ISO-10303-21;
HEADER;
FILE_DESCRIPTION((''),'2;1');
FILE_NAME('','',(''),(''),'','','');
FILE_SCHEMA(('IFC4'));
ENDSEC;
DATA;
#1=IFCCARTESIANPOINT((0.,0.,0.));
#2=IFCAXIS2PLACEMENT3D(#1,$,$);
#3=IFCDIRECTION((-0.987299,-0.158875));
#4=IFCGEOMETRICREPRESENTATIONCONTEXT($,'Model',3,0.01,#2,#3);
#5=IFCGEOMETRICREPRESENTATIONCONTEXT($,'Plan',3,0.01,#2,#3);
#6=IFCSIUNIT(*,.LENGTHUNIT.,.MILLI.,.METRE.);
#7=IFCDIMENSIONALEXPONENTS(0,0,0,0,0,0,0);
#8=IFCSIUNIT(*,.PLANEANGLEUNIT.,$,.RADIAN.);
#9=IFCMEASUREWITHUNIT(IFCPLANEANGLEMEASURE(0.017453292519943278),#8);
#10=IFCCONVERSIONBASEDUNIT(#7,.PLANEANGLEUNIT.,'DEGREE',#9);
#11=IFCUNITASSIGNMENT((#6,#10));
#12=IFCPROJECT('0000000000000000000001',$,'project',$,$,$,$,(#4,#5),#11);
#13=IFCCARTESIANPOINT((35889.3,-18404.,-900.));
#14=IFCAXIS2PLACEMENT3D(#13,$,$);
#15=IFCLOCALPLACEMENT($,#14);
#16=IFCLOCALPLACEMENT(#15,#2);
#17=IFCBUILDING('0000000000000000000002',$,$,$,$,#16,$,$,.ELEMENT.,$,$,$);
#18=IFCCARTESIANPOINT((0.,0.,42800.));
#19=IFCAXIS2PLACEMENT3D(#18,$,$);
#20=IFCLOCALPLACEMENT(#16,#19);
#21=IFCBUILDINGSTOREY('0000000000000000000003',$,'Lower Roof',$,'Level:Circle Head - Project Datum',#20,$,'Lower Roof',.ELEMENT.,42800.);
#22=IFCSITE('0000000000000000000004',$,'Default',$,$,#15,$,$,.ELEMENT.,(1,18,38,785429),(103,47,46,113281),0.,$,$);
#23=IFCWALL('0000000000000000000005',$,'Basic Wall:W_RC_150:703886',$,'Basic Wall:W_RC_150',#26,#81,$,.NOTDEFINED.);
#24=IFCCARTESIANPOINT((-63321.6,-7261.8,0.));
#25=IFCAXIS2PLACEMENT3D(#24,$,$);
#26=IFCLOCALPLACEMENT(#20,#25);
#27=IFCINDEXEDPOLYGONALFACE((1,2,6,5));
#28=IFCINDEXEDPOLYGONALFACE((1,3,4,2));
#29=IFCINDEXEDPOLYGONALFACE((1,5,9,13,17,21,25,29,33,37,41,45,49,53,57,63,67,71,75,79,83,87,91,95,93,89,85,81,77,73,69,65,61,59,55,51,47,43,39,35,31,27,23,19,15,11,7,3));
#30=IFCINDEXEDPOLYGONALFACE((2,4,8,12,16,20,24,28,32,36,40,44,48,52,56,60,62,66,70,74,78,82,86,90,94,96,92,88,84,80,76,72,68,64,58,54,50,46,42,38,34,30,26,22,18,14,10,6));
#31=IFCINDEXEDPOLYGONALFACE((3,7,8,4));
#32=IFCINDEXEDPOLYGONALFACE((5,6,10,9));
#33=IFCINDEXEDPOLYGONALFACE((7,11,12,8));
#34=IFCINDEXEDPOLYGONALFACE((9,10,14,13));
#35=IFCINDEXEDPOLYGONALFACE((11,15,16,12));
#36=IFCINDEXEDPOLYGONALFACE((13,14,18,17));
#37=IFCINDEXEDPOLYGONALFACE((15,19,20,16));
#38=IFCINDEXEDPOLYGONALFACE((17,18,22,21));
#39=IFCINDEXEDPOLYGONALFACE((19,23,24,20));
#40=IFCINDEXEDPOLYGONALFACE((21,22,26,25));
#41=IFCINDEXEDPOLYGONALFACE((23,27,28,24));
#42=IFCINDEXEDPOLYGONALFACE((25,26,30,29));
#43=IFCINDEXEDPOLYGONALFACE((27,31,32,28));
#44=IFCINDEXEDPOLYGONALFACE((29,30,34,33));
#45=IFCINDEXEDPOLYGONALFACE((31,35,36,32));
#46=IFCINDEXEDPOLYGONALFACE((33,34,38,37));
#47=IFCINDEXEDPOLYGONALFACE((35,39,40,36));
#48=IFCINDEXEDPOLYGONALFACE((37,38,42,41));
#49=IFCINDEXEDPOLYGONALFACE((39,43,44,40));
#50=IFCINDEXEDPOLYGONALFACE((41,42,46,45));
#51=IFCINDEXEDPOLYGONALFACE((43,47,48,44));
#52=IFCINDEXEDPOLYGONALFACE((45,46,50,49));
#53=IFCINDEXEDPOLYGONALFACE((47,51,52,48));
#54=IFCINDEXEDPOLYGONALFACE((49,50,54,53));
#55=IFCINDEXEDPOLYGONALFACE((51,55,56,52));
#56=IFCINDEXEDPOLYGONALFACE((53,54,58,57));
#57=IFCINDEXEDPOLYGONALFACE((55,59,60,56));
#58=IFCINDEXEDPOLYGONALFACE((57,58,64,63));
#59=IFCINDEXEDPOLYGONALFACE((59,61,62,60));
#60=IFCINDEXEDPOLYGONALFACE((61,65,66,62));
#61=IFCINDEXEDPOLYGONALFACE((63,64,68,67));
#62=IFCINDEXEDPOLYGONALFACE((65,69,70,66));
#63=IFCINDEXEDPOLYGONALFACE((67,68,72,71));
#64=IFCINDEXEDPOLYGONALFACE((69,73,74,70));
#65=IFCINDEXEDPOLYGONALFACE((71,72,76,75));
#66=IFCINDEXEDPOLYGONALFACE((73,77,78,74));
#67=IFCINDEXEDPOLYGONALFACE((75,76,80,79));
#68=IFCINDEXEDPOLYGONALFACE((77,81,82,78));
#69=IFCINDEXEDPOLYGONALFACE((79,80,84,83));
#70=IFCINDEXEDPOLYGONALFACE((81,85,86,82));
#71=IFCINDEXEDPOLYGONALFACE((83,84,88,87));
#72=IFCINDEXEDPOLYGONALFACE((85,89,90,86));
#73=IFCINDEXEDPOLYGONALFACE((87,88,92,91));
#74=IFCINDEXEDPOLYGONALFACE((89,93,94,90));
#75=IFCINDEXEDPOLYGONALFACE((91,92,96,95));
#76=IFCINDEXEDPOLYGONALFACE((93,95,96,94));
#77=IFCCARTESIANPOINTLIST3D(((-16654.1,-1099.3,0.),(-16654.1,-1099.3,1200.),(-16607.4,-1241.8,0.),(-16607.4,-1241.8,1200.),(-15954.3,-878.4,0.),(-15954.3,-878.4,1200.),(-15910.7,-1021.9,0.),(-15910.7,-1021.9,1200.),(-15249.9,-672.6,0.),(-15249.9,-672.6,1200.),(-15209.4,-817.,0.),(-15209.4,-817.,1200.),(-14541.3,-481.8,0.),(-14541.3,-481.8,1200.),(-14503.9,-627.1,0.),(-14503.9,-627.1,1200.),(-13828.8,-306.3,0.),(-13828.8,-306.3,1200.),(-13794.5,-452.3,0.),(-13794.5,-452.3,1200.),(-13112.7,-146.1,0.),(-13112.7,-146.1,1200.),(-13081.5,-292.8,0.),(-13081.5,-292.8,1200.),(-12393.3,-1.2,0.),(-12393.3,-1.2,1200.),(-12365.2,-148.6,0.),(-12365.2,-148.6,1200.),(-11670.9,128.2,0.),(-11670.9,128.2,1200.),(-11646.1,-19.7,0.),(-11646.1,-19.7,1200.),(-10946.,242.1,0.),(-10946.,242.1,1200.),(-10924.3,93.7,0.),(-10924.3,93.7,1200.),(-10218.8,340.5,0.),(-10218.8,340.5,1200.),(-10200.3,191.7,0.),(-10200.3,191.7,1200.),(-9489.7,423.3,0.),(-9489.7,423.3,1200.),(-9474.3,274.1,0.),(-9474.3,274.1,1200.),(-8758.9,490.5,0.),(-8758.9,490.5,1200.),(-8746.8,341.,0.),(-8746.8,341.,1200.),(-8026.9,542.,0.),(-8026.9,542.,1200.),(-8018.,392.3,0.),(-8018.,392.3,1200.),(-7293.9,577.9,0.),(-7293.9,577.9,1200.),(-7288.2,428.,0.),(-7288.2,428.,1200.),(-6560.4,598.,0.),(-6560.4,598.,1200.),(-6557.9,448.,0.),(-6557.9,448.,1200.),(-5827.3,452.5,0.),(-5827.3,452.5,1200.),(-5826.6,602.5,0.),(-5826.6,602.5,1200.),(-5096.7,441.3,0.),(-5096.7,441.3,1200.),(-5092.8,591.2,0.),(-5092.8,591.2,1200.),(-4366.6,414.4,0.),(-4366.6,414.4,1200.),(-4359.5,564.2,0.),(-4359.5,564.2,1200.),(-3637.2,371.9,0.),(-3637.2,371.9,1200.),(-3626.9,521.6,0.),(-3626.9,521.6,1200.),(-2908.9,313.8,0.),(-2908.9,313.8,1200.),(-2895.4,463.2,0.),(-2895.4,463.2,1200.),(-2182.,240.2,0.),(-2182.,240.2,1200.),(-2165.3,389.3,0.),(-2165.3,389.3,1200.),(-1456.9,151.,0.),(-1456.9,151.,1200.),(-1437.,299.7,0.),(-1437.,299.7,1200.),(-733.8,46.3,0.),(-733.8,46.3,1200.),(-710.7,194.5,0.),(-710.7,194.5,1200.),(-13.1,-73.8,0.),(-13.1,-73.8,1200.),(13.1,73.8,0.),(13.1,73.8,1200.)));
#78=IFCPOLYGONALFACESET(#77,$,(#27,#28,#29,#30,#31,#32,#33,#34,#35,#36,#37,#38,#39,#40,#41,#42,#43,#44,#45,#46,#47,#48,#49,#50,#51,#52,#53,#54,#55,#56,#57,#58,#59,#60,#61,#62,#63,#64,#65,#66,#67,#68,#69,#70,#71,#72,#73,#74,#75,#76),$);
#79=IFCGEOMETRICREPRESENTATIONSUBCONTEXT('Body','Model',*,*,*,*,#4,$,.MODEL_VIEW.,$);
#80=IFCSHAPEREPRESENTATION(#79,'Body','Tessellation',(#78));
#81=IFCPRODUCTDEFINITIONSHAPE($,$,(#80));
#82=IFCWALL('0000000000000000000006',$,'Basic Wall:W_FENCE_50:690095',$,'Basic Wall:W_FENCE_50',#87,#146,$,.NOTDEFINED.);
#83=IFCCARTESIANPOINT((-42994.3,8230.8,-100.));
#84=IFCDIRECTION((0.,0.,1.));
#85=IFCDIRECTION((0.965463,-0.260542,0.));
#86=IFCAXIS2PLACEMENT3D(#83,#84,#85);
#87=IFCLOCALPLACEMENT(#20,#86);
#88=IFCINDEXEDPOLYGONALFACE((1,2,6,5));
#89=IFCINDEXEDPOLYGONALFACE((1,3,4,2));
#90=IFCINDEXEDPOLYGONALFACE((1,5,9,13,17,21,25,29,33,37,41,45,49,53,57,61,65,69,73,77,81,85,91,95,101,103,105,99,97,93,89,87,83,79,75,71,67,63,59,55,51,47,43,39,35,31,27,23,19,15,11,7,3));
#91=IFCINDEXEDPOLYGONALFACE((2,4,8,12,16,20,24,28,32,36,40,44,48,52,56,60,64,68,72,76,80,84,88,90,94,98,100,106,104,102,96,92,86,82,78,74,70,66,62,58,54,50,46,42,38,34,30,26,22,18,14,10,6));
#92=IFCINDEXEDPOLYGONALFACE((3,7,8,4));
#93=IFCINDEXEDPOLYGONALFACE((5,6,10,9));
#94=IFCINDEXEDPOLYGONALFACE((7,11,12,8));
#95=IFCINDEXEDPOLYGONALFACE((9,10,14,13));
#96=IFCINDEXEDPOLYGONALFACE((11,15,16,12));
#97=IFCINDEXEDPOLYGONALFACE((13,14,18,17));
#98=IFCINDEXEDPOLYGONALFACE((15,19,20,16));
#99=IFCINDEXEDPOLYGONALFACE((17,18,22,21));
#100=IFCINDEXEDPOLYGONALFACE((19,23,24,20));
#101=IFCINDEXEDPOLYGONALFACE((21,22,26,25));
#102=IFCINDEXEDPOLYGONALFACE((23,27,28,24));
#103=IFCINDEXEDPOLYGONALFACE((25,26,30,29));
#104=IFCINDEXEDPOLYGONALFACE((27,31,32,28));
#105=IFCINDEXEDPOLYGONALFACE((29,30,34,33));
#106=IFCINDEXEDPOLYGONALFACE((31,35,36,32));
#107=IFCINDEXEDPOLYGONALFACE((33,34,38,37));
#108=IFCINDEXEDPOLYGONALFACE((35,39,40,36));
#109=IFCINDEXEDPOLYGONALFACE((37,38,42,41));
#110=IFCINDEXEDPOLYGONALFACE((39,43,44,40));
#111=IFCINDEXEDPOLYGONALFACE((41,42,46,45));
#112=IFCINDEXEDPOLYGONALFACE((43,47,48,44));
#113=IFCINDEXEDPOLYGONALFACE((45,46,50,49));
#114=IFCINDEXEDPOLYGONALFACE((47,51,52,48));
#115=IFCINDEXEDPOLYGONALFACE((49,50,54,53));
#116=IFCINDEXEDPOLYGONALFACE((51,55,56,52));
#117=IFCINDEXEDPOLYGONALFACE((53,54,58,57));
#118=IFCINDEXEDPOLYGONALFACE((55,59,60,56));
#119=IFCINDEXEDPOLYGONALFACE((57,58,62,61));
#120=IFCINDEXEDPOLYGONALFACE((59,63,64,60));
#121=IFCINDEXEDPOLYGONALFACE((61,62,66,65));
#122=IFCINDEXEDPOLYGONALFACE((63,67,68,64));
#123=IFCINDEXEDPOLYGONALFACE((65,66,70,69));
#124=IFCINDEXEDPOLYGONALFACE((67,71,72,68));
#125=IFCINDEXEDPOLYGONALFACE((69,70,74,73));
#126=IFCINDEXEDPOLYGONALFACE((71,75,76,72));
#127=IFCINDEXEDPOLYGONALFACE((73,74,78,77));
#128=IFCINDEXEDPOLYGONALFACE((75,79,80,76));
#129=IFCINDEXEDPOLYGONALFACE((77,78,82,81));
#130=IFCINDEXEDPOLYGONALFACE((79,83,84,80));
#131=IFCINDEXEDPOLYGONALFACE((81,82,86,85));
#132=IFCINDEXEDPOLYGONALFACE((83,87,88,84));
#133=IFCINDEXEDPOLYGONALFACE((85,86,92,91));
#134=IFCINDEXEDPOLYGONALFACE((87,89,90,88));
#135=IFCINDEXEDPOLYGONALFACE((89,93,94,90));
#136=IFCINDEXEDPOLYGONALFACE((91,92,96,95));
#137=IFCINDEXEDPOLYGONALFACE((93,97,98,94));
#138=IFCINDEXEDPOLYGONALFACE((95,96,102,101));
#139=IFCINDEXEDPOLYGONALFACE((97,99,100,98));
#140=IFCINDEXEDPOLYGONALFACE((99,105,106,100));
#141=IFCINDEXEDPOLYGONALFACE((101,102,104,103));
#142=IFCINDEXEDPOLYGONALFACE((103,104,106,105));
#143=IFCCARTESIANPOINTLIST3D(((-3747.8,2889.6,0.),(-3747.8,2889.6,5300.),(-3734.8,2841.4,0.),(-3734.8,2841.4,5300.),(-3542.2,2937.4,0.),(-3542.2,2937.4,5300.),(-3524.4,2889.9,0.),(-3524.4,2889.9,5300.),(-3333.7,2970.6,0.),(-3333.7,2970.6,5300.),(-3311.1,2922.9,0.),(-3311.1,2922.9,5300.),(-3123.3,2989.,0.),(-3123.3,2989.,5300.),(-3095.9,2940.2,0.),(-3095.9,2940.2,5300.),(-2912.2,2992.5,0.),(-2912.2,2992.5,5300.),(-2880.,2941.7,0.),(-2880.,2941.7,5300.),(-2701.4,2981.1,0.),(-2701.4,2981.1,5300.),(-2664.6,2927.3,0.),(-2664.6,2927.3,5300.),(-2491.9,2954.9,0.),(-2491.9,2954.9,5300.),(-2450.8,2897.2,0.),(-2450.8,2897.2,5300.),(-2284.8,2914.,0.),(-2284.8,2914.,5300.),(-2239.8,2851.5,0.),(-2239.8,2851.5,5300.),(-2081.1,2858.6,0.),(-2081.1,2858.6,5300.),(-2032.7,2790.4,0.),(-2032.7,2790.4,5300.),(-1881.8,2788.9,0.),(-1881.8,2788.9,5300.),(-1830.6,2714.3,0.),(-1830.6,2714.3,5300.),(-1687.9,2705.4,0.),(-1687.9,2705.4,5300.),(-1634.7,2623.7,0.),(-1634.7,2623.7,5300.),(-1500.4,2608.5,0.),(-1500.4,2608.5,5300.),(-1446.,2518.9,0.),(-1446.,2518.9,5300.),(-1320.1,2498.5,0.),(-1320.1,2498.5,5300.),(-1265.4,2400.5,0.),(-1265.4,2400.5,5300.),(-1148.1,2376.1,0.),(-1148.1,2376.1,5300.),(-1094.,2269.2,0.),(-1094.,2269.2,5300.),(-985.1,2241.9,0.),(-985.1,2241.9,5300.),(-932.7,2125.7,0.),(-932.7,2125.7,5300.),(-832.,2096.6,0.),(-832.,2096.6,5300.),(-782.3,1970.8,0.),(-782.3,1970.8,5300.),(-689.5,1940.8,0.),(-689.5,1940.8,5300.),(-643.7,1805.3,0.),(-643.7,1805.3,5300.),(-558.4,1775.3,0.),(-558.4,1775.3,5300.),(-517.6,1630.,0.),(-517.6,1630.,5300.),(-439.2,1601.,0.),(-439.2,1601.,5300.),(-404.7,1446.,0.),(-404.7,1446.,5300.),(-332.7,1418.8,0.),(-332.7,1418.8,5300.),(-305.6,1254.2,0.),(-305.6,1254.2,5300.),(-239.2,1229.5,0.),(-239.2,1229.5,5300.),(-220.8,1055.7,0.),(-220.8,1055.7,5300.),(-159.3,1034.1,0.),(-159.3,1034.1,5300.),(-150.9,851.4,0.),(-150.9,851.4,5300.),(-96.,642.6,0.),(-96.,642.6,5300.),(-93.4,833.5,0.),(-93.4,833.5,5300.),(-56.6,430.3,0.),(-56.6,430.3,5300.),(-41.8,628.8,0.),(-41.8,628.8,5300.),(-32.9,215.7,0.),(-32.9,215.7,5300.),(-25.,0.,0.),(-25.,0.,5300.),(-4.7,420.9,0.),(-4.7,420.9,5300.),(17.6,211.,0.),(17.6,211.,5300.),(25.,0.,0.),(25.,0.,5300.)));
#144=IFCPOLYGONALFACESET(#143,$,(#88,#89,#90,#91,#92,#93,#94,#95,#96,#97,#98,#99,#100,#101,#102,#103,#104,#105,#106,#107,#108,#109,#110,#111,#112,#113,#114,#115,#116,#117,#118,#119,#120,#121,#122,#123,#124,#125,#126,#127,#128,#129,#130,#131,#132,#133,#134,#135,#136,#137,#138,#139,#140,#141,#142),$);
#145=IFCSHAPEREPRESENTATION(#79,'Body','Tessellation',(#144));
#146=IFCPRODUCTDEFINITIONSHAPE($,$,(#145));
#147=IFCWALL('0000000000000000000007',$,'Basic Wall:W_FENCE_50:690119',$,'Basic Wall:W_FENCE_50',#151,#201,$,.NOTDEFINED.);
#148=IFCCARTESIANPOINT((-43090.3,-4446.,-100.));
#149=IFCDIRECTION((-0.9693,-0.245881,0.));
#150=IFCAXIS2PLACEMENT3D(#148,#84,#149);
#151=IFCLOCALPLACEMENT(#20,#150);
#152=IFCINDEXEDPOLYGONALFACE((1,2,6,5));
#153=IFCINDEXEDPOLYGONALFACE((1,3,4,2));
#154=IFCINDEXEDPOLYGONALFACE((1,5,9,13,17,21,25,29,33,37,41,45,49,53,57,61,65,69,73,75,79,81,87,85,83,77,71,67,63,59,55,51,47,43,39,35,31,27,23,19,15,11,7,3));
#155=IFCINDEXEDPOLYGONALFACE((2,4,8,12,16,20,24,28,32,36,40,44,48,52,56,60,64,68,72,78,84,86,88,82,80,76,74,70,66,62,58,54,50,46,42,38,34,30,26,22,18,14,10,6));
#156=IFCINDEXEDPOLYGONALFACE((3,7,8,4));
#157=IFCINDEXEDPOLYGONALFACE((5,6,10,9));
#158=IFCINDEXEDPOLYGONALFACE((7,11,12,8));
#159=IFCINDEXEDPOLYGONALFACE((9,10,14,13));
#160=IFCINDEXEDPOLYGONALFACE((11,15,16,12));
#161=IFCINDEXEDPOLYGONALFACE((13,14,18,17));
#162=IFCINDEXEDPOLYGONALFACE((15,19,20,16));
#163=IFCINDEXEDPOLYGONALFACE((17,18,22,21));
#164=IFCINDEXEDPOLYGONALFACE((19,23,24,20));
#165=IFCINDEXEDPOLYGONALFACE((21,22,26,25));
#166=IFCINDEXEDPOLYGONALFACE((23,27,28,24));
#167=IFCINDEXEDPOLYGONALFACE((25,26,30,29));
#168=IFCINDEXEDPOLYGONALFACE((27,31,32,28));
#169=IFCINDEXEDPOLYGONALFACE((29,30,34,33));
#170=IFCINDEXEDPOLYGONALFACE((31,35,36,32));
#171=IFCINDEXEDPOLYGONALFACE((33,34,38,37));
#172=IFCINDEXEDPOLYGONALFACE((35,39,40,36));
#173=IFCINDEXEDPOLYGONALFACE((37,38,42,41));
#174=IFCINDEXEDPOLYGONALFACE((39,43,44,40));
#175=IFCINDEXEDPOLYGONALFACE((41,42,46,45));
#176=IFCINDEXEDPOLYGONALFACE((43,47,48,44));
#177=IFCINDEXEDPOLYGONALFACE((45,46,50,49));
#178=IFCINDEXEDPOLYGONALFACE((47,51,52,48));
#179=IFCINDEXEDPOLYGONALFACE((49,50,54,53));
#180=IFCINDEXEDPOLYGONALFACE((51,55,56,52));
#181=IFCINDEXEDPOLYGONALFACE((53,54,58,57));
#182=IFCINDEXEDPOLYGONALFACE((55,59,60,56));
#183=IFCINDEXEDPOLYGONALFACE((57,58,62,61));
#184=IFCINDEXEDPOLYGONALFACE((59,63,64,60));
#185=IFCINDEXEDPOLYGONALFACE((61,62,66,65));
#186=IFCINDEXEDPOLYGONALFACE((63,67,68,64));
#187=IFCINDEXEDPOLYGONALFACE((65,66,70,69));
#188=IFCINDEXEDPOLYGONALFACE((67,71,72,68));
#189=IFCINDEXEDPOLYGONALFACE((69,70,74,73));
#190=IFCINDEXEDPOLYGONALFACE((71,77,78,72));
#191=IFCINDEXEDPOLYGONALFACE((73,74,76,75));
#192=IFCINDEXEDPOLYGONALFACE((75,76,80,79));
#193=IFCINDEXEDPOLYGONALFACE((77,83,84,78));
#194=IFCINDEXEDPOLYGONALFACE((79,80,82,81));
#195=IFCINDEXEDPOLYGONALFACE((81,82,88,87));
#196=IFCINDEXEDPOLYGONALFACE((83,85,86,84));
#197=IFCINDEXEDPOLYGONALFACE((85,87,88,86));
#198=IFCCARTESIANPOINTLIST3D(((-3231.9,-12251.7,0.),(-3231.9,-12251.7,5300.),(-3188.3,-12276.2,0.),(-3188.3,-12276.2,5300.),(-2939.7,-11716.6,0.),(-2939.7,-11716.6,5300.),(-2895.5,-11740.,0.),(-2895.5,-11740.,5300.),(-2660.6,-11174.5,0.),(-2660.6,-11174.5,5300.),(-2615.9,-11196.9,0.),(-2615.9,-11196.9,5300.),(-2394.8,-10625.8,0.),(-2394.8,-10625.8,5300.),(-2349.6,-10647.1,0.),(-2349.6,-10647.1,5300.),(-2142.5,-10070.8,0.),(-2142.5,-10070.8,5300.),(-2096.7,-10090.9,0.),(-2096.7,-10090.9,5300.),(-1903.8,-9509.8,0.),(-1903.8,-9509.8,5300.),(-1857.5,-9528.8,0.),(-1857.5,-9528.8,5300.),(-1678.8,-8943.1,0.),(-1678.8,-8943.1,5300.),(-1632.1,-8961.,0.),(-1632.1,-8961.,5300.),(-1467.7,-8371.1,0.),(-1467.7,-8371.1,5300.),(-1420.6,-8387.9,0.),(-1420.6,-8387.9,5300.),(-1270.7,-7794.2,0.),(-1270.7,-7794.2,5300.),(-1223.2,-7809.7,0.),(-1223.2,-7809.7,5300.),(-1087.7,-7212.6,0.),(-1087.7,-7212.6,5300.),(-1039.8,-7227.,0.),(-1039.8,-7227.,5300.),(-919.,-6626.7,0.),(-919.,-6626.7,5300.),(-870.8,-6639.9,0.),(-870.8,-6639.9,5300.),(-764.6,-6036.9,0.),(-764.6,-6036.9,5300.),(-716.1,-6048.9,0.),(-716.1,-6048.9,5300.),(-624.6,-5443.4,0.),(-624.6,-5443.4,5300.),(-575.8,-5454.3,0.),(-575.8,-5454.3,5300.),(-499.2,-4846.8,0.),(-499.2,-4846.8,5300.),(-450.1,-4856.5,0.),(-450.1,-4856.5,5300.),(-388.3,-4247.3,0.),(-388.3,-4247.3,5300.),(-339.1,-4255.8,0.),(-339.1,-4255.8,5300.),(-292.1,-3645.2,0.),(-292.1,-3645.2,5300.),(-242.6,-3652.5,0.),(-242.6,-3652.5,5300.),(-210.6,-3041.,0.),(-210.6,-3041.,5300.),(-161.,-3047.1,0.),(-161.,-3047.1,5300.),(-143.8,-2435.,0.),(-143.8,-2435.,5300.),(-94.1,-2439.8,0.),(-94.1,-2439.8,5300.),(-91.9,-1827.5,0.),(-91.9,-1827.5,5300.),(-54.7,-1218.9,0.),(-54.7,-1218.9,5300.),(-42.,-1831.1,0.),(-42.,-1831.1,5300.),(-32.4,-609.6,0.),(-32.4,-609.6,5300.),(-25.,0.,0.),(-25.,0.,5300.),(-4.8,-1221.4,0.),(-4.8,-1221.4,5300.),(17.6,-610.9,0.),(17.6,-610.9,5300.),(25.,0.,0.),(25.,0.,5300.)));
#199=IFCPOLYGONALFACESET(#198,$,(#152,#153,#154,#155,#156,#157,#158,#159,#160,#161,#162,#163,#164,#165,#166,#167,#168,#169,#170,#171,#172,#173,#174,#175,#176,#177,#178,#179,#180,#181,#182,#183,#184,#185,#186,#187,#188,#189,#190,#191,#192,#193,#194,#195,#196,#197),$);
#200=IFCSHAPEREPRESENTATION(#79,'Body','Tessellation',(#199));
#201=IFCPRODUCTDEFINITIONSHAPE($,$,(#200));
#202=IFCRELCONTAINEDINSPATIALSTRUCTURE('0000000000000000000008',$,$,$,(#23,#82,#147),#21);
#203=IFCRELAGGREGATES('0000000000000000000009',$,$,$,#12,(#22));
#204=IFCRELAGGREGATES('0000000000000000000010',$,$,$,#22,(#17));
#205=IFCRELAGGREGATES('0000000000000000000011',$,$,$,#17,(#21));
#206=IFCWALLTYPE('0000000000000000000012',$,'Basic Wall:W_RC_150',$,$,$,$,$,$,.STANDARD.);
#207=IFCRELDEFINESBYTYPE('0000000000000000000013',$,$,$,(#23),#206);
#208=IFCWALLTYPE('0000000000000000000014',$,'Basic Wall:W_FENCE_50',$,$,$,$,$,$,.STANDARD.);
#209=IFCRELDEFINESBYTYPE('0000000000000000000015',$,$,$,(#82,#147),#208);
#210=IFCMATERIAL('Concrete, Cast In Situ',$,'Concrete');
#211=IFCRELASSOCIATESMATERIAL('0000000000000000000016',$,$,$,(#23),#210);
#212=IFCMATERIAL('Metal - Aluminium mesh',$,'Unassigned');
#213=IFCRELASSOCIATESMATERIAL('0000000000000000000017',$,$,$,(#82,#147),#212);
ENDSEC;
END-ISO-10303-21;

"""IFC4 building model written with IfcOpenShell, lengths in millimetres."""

from ifc_helpers import new_model, entity, si_unit, converted_unit, direction, frame, origin, place, context, subcontext, project, spatial, line, arc, indexed_curve, outline, extrude, material, type_object, element, save


model = new_model("IFC4")

# Units and contexts
model_context = context("Model", 3, precision=0.01, world=origin(), true_north=direction((-0.987299, -0.158875)))
plan_context = context("Plan", 3, precision=0.01, world=origin(), true_north=direction((-0.987299, -0.158875)))
body_context = subcontext(model_context, "Body", "Model", "MODEL_VIEW")
ifc_project = project(units=[si_unit("LENGTHUNIT", "METRE", prefix="MILLI"), converted_unit("PLANEANGLEUNIT", "DEGREE", entity("IfcPlaneAngleMeasure", 0.017453292519943278), si_unit("PLANEANGLEUNIT", "RADIAN"), dimensions=[0, 0, 0, 0, 0, 0, 0])], contexts=[model_context, plan_context])

# Site, building, storey
site_placement = place(None, frame((35889.3, -18404.0, -900.0)))
site = spatial("IfcSite", under=ifc_project, at=site_placement, Name="Default", CompositionType="ELEMENT", RefLatitude=(1, 18, 38, 785429), RefLongitude=(103, 47, 46, 113281), RefElevation=0.0)
building_placement = place(site_placement, origin())
building = spatial("IfcBuilding", under=site, at=building_placement, CompositionType="ELEMENT")
storey_placement = place(building_placement, frame((0.0, 0.0, 42800.0)))
storey = spatial("IfcBuildingStorey", under=building, at=storey_placement, Name="Lower Roof", ObjectType="Level:Circle Head - Project Datum", LongName="Lower Roof", CompositionType="ELEMENT", Elevation=42800.0)

# Walls
ifc_material_1 = material(Name="Concrete, Cast In Situ", Category="Concrete")
wall_type_1 = type_object("IfcWallType", Name="Basic Wall:W_RC_150", PredefinedType="STANDARD")
wall_1_placement = place(storey_placement, frame((-63321.6, -7261.8, 0.0)))
element("IfcWall", 1, at=wall_1_placement, inside=storey, type_object=wall_type_1, material=ifc_material_1, Name="Basic Wall:W_RC_150:703886", ObjectType="Basic Wall:W_RC_150", PredefinedType="NOTDEFINED", context=body_context, shape_type="SweptSolid", body=[
    extrude(outline(indexed_curve([(-16607.4, -1241.8), (-8382.5, 368.6), (-13.1, -73.8), (13.1, 73.8), (-8393.0, 518.2), (-16654.1, -1099.3)], segments=[arc(1, 2, 3), line(3, 4), arc(4, 5, 6), line(6, 1)], self_intersect=False)), origin(), (0.0, 0.0, 1.0), 1200.0),
])
ifc_material_2 = material(Name="Metal - Aluminium mesh", Category="Unassigned")
wall_type_2 = type_object("IfcWallType", Name="Basic Wall:W_FENCE_50", PredefinedType="STANDARD")
wall_2_placement = place(storey_placement, frame((-42994.3, 8230.8, -100.0), z_axis=(0.0, 0.0, 1.0), x_axis=(0.965463, -0.260542, 0.0)))
element("IfcWall", 2, at=wall_2_placement, inside=storey, type_object=wall_type_2, material=ifc_material_2, Name="Basic Wall:W_FENCE_50:690095", ObjectType="Basic Wall:W_FENCE_50", PredefinedType="NOTDEFINED", context=body_context, shape_type="SweptSolid", body=[
    extrude(outline(indexed_curve([(-3734.8, 2841.4), (-1178.5, 2336.4), (-25.0, 0.0), (25.0, 0.0), (-1148.1, 2376.1), (-3747.8, 2889.6)], segments=[arc(1, 2, 3), line(3, 4), arc(4, 5, 6), line(6, 1)], self_intersect=False)), origin(), (0.0, 0.0, 1.0), 5300.0),
])
wall_3_placement = place(storey_placement, frame((-43090.3, -4446.0, -100.0), z_axis=(0.0, 0.0, 1.0), x_axis=(-0.9693, -0.245881, 0.0)))
element("IfcWall", 3, at=wall_3_placement, inside=storey, type_object=wall_type_2, material=ifc_material_2, Name="Basic Wall:W_FENCE_50:690119", ObjectType="Basic Wall:W_FENCE_50", PredefinedType="NOTDEFINED", context=body_context, shape_type="SweptSolid", body=[
    extrude(outline(indexed_curve([(-3188.3, -12276.2), (-791.6, -6344.9), (25.0, 0.0), (-25.0, 0.0), (-840.0, -6332.2), (-3231.9, -12251.7)], segments=[arc(1, 2, 3), line(3, 4), arc(4, 5, 6), line(6, 1)], self_intersect=False)), origin(), (0.0, 0.0, 1.0), 5300.0),
])

save(model, "model.ifc")
